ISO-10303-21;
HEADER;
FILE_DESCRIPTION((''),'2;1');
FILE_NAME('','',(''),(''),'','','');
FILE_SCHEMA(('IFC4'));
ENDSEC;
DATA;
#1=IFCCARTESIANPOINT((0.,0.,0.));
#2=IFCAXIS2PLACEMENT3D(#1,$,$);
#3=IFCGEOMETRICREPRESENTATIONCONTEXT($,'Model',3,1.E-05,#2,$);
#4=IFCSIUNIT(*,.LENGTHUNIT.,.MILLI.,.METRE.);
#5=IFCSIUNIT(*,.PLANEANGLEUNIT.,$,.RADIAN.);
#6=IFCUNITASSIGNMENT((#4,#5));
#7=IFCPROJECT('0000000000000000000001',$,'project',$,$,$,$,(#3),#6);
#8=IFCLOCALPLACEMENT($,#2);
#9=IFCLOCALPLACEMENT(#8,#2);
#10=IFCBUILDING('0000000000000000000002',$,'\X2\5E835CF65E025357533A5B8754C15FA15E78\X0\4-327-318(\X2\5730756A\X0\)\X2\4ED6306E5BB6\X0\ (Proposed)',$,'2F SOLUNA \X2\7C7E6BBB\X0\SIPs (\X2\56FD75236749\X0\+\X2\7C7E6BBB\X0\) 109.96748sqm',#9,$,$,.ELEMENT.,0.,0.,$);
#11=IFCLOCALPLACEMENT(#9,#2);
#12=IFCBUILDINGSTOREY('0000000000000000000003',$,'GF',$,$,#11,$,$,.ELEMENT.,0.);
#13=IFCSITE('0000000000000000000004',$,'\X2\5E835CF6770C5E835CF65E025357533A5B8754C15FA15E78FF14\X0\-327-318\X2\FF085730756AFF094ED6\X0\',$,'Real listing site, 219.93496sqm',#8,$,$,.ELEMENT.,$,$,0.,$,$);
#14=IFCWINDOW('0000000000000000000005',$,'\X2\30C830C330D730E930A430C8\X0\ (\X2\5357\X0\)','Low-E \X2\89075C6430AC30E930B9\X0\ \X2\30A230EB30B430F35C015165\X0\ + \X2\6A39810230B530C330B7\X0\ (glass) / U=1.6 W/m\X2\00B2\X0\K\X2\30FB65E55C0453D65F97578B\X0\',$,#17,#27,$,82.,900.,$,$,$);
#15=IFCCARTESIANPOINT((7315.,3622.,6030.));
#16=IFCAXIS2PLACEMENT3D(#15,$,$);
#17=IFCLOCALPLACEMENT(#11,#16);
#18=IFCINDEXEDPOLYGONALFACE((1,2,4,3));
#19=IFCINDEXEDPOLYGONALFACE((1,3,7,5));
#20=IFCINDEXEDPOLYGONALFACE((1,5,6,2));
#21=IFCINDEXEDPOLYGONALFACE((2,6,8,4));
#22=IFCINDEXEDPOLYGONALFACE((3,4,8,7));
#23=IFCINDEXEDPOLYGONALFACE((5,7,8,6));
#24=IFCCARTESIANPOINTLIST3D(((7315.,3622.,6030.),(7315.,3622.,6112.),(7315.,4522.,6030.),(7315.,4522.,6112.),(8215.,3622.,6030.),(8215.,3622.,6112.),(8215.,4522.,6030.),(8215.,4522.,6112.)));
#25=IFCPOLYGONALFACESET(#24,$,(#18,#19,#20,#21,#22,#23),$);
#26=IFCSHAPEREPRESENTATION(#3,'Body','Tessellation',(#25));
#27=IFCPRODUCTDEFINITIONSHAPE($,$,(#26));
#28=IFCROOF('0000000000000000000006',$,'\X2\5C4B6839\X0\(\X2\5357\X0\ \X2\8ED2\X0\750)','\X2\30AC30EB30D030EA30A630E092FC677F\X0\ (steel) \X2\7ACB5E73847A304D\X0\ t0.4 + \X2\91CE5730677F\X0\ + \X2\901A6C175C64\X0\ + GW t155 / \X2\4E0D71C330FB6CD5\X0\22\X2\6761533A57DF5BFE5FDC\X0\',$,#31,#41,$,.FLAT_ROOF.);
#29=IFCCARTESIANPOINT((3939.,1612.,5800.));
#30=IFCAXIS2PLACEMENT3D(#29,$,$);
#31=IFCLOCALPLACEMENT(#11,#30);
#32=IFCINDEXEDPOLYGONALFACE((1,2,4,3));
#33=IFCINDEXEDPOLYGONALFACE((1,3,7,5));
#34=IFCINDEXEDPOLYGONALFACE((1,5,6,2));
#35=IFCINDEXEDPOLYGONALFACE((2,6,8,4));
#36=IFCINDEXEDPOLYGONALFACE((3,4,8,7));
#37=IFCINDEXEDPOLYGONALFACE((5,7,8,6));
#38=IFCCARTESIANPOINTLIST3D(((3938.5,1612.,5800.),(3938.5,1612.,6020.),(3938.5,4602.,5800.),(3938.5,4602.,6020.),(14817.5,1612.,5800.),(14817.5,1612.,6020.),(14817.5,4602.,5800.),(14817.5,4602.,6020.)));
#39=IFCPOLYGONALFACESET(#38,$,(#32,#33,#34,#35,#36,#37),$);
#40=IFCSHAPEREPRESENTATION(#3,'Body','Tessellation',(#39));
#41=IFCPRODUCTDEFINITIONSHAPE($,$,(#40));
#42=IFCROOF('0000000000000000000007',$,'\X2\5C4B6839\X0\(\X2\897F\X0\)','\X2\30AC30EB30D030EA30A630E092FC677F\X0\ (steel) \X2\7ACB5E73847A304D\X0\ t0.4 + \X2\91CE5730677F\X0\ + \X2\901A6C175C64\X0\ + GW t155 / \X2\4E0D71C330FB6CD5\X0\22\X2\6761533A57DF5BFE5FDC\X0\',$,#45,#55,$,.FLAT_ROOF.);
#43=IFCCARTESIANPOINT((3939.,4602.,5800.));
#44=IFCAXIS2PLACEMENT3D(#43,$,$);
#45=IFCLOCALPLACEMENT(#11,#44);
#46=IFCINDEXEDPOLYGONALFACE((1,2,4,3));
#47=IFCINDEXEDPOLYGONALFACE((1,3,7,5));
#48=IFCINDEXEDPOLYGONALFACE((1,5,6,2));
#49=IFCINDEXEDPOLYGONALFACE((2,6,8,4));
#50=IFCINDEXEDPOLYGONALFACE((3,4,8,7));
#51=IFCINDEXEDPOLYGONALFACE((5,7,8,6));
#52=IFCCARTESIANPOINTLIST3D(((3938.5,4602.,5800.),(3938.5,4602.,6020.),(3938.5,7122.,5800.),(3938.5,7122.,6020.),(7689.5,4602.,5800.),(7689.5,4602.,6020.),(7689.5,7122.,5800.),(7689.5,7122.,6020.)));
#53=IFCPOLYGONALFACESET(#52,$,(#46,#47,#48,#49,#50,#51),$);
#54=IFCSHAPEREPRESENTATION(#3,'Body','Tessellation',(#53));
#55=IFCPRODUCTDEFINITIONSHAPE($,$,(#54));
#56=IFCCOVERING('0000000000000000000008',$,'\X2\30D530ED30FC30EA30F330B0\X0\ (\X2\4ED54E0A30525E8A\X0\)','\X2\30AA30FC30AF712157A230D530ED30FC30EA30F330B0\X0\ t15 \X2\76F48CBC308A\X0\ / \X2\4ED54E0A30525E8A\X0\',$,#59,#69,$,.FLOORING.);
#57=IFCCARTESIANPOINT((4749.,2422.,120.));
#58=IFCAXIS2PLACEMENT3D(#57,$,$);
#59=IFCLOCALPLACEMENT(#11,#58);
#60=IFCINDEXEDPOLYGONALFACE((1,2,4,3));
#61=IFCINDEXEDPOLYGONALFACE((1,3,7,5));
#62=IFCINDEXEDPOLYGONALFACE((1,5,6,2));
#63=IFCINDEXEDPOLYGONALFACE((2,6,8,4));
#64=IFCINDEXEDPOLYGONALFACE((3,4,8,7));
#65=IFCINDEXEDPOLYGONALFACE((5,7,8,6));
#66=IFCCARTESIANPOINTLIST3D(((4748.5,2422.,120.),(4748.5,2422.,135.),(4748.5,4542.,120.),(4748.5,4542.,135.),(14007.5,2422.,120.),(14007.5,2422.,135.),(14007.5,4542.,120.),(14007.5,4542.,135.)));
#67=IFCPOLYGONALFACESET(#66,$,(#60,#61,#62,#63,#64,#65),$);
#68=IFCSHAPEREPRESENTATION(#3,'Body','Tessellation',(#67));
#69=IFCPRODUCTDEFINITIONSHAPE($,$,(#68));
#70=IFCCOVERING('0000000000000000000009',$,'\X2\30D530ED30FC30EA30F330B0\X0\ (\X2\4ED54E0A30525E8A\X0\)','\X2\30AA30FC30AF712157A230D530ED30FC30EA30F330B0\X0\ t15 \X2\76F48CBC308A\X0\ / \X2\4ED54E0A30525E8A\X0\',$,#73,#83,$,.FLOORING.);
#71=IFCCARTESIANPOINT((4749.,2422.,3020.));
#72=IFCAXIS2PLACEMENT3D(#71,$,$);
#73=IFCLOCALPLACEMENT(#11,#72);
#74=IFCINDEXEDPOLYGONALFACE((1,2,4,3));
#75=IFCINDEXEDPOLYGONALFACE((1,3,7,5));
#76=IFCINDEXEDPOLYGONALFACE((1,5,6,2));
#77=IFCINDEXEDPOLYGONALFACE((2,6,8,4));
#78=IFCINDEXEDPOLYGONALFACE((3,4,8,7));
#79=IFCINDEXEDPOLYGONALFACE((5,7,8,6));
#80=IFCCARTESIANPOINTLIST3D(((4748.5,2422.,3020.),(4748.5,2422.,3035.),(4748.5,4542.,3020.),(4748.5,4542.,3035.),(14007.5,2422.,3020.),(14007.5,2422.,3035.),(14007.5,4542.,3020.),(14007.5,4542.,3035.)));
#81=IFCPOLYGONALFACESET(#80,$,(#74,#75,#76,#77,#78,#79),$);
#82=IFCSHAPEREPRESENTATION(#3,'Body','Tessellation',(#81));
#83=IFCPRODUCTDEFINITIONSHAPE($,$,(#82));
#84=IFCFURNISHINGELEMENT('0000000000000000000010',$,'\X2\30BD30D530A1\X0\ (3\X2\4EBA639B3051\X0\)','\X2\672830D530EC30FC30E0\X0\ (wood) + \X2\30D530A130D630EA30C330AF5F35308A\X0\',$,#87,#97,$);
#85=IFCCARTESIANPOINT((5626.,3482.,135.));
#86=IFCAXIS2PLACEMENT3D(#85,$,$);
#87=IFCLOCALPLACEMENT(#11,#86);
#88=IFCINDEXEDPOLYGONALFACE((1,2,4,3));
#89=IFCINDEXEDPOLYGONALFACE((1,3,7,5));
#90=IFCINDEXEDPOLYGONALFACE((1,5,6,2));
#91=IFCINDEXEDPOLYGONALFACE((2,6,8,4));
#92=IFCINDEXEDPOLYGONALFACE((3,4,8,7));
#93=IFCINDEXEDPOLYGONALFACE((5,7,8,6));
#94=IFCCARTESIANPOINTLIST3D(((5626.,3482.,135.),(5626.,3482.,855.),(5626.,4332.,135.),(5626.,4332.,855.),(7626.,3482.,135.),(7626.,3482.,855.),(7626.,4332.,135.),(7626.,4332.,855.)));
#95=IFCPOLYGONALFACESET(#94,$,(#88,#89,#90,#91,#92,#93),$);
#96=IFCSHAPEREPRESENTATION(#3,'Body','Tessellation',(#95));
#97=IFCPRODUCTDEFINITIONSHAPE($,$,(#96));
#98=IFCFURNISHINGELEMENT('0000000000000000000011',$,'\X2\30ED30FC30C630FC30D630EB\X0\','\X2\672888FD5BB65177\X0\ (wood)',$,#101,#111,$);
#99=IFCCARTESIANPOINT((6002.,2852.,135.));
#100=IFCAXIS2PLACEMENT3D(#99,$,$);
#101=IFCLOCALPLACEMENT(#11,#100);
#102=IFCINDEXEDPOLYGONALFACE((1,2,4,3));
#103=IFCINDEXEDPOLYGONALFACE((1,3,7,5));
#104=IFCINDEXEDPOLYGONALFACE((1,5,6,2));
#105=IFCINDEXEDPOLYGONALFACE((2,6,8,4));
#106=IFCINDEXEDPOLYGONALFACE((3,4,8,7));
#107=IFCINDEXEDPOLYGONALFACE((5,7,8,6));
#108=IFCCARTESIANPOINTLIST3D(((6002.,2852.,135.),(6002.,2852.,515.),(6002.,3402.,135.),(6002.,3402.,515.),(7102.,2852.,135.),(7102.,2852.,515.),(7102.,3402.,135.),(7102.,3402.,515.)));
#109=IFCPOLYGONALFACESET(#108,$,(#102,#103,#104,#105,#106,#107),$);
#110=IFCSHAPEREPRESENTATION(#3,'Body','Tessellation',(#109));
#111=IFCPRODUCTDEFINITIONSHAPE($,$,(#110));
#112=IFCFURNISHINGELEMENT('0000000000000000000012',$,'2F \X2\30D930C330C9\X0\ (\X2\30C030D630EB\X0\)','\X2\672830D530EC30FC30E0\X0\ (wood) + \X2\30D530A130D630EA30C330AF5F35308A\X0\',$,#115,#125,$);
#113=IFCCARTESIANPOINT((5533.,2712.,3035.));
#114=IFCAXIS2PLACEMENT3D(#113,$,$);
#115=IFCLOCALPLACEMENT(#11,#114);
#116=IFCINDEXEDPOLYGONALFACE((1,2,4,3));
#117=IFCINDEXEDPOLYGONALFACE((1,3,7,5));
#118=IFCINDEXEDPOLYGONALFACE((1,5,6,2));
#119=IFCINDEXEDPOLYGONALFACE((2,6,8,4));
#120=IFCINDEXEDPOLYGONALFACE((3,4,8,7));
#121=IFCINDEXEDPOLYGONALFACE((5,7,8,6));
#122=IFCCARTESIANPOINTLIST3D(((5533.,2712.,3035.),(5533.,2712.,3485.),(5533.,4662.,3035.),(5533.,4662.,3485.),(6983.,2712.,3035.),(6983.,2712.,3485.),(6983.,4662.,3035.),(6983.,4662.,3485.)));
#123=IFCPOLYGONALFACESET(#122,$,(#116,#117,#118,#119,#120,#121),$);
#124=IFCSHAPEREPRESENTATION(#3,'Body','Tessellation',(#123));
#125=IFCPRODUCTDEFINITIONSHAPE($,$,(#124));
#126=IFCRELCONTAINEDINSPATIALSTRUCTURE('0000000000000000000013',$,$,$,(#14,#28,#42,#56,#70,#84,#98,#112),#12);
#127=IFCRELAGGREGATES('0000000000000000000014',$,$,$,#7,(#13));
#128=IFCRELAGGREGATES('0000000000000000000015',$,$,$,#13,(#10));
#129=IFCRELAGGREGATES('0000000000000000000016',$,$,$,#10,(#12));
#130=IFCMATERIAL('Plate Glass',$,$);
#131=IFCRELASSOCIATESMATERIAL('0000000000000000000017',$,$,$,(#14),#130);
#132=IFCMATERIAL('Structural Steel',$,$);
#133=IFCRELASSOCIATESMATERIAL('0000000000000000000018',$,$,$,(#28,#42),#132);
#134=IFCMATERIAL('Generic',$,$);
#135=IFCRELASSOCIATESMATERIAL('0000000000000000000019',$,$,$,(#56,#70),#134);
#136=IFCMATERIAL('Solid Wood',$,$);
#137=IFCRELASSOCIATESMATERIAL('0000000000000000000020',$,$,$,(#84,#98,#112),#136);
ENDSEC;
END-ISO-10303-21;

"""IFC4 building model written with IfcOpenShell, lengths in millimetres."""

from ifc_helpers import new_model, si_unit, frame, frame_2d, origin, place, context, project, spatial, rectangle, extrude, material, element, save


model = new_model("IFC4")

# Units and contexts
model_context = context("Model", 3, precision=1e-05, world=origin())
ifc_project = project(units=[si_unit("LENGTHUNIT", "METRE", prefix="MILLI"), si_unit("PLANEANGLEUNIT", "RADIAN")], contexts=[model_context])

# Site, building, storey
site_placement = place(None, origin())
site = spatial("IfcSite", under=ifc_project, at=site_placement, Name="広島県広島市南区宇品御幸４-327-318（地番）他", ObjectType="Real listing site, 219.93496sqm", CompositionType="ELEMENT", RefElevation=0.0)
building_placement = place(site_placement, origin())
building = spatial("IfcBuilding", under=site, at=building_placement, Name="広島市南区宇品御幸4-327-318(地番)他の家 (Proposed)", ObjectType="2F SOLUNA 籾殻SIPs (国産杉+籾殻) 109.96748sqm", CompositionType="ELEMENT", ElevationOfRefHeight=0.0, ElevationOfTerrain=0.0)
storey_placement = place(building_placement, origin())
storey = spatial("IfcBuildingStorey", under=building, at=storey_placement, Name="GF", CompositionType="ELEMENT", Elevation=0.0)

# Shared definitions
ifc_material_1 = material(Name="Solid Wood")

# Shared definitions
ifc_material_2 = material(Name="Plate Glass")

# Window
window_1_placement = place(storey_placement, frame((7315.0, 3622.0, 6030.0)))
element("IfcWindow", 1, at=window_1_placement, inside=storey, material=ifc_material_2, Name="トップライト (南)", Description="Low-E 複層ガラス アルゴン封入 + 樹脂サッシ (glass) / U=1.6 W/m²K・日射取得型", OverallHeight=82.0, OverallWidth=900.0, context=model_context, shape_type="SweptSolid", body=[
    extrude(rectangle(XDim=900.0, YDim=900.0, at=frame_2d((450.0, 450.0))), frame((7315.0, 3622.0, 6030.0)), (0.0, 0.0, 1.0), 82.0),
])

# Roofs
ifc_material_3 = material(Name="Structural Steel")
roof_1_placement = place(storey_placement, frame((3939.0, 1612.0, 5800.0)))
element("IfcRoof", 2, at=roof_1_placement, inside=storey, material=ifc_material_3, Name="屋根(南 軒750)", Description="ガルバリウム鋼板 (steel) 立平葺き t0.4 + 野地板 + 通気層 + GW t155 / 不燃・法22条区域対応", PredefinedType="FLAT_ROOF", context=model_context, shape_type="SweptSolid", body=[
    extrude(rectangle(XDim=10879.0, YDim=2990.0, at=frame_2d((5439.0, 1495.0))), frame((3939.0, 1612.0, 5800.0)), (0.0, 0.0, 1.0), 220.0),
])
roof_2_placement = place(storey_placement, frame((3939.0, 4602.0, 5800.0)))
element("IfcRoof", 3, at=roof_2_placement, inside=storey, material=ifc_material_3, Name="屋根(西)", Description="ガルバリウム鋼板 (steel) 立平葺き t0.4 + 野地板 + 通気層 + GW t155 / 不燃・法22条区域対応", PredefinedType="FLAT_ROOF", context=model_context, shape_type="SweptSolid", body=[
    extrude(rectangle(XDim=3751.0, YDim=2520.0, at=frame_2d((1875.0, 1260.0))), frame((3939.0, 4602.0, 5800.0)), (0.0, 0.0, 1.0), 220.0),
])

# Coverings
ifc_material_4 = material(Name="Generic")
covering_1_placement = place(storey_placement, frame((4749.0, 2422.0, 120.0)))
element("IfcCovering", 4, at=covering_1_placement, inside=storey, material=ifc_material_4, Name="フローリング (仕上げ床)", Description="オーク無垢フローリング t15 直貼り / 仕上げ床", PredefinedType="FLOORING", context=model_context, shape_type="SweptSolid", body=[
    extrude(rectangle(XDim=9259.0, YDim=2120.0, at=frame_2d((4629.0, 1060.0))), frame((4749.0, 2422.0, 120.0)), (0.0, 0.0, 1.0), 15.0),
])
covering_2_placement = place(storey_placement, frame((4749.0, 2422.0, 3020.0)))
element("IfcCovering", 5, at=covering_2_placement, inside=storey, material=ifc_material_4, Name="フローリング (仕上げ床)", Description="オーク無垢フローリング t15 直貼り / 仕上げ床", PredefinedType="FLOORING", context=model_context, shape_type="SweptSolid", body=[
    extrude(rectangle(XDim=9259.0, YDim=2120.0, at=frame_2d((4629.0, 1060.0))), frame((4749.0, 2422.0, 3020.0)), (0.0, 0.0, 1.0), 15.0),
])

# Furnishing elements
furnishing_1_placement = place(storey_placement, frame((5626.0, 3482.0, 135.0)))
element("IfcFurnishingElement", 6, at=furnishing_1_placement, inside=storey, material=ifc_material_1, Name="ソファ (3人掛け)", Description="木フレーム (wood) + ファブリック張り", context=model_context, shape_type="SweptSolid", body=[
    extrude(rectangle(XDim=2000.0, YDim=850.0, at=frame_2d((1000.0, 425.0))), frame((5626.0, 3482.0, 135.0)), (0.0, 0.0, 1.0), 720.0),
])
furnishing_2_placement = place(storey_placement, frame((6002.0, 2852.0, 135.0)))
element("IfcFurnishingElement", 7, at=furnishing_2_placement, inside=storey, material=ifc_material_1, Name="ローテーブル", Description="木製家具 (wood)", context=model_context, shape_type="SweptSolid", body=[
    extrude(rectangle(XDim=1100.0, YDim=550.0, at=frame_2d((550.0, 275.0))), frame((6002.0, 2852.0, 135.0)), (0.0, 0.0, 1.0), 380.0),
])
furnishing_3_placement = place(storey_placement, frame((5533.0, 2712.0, 3035.0)))
element("IfcFurnishingElement", 8, at=furnishing_3_placement, inside=storey, material=ifc_material_1, Name="2F ベッド (ダブル)", Description="木フレーム (wood) + ファブリック張り", context=model_context, shape_type="SweptSolid", body=[
    extrude(rectangle(XDim=1450.0, YDim=1950.0, at=frame_2d((725.0, 975.0))), frame((5533.0, 2712.0, 3035.0)), (0.0, 0.0, 1.0), 450.0),
])

save(model, "model.ifc")
